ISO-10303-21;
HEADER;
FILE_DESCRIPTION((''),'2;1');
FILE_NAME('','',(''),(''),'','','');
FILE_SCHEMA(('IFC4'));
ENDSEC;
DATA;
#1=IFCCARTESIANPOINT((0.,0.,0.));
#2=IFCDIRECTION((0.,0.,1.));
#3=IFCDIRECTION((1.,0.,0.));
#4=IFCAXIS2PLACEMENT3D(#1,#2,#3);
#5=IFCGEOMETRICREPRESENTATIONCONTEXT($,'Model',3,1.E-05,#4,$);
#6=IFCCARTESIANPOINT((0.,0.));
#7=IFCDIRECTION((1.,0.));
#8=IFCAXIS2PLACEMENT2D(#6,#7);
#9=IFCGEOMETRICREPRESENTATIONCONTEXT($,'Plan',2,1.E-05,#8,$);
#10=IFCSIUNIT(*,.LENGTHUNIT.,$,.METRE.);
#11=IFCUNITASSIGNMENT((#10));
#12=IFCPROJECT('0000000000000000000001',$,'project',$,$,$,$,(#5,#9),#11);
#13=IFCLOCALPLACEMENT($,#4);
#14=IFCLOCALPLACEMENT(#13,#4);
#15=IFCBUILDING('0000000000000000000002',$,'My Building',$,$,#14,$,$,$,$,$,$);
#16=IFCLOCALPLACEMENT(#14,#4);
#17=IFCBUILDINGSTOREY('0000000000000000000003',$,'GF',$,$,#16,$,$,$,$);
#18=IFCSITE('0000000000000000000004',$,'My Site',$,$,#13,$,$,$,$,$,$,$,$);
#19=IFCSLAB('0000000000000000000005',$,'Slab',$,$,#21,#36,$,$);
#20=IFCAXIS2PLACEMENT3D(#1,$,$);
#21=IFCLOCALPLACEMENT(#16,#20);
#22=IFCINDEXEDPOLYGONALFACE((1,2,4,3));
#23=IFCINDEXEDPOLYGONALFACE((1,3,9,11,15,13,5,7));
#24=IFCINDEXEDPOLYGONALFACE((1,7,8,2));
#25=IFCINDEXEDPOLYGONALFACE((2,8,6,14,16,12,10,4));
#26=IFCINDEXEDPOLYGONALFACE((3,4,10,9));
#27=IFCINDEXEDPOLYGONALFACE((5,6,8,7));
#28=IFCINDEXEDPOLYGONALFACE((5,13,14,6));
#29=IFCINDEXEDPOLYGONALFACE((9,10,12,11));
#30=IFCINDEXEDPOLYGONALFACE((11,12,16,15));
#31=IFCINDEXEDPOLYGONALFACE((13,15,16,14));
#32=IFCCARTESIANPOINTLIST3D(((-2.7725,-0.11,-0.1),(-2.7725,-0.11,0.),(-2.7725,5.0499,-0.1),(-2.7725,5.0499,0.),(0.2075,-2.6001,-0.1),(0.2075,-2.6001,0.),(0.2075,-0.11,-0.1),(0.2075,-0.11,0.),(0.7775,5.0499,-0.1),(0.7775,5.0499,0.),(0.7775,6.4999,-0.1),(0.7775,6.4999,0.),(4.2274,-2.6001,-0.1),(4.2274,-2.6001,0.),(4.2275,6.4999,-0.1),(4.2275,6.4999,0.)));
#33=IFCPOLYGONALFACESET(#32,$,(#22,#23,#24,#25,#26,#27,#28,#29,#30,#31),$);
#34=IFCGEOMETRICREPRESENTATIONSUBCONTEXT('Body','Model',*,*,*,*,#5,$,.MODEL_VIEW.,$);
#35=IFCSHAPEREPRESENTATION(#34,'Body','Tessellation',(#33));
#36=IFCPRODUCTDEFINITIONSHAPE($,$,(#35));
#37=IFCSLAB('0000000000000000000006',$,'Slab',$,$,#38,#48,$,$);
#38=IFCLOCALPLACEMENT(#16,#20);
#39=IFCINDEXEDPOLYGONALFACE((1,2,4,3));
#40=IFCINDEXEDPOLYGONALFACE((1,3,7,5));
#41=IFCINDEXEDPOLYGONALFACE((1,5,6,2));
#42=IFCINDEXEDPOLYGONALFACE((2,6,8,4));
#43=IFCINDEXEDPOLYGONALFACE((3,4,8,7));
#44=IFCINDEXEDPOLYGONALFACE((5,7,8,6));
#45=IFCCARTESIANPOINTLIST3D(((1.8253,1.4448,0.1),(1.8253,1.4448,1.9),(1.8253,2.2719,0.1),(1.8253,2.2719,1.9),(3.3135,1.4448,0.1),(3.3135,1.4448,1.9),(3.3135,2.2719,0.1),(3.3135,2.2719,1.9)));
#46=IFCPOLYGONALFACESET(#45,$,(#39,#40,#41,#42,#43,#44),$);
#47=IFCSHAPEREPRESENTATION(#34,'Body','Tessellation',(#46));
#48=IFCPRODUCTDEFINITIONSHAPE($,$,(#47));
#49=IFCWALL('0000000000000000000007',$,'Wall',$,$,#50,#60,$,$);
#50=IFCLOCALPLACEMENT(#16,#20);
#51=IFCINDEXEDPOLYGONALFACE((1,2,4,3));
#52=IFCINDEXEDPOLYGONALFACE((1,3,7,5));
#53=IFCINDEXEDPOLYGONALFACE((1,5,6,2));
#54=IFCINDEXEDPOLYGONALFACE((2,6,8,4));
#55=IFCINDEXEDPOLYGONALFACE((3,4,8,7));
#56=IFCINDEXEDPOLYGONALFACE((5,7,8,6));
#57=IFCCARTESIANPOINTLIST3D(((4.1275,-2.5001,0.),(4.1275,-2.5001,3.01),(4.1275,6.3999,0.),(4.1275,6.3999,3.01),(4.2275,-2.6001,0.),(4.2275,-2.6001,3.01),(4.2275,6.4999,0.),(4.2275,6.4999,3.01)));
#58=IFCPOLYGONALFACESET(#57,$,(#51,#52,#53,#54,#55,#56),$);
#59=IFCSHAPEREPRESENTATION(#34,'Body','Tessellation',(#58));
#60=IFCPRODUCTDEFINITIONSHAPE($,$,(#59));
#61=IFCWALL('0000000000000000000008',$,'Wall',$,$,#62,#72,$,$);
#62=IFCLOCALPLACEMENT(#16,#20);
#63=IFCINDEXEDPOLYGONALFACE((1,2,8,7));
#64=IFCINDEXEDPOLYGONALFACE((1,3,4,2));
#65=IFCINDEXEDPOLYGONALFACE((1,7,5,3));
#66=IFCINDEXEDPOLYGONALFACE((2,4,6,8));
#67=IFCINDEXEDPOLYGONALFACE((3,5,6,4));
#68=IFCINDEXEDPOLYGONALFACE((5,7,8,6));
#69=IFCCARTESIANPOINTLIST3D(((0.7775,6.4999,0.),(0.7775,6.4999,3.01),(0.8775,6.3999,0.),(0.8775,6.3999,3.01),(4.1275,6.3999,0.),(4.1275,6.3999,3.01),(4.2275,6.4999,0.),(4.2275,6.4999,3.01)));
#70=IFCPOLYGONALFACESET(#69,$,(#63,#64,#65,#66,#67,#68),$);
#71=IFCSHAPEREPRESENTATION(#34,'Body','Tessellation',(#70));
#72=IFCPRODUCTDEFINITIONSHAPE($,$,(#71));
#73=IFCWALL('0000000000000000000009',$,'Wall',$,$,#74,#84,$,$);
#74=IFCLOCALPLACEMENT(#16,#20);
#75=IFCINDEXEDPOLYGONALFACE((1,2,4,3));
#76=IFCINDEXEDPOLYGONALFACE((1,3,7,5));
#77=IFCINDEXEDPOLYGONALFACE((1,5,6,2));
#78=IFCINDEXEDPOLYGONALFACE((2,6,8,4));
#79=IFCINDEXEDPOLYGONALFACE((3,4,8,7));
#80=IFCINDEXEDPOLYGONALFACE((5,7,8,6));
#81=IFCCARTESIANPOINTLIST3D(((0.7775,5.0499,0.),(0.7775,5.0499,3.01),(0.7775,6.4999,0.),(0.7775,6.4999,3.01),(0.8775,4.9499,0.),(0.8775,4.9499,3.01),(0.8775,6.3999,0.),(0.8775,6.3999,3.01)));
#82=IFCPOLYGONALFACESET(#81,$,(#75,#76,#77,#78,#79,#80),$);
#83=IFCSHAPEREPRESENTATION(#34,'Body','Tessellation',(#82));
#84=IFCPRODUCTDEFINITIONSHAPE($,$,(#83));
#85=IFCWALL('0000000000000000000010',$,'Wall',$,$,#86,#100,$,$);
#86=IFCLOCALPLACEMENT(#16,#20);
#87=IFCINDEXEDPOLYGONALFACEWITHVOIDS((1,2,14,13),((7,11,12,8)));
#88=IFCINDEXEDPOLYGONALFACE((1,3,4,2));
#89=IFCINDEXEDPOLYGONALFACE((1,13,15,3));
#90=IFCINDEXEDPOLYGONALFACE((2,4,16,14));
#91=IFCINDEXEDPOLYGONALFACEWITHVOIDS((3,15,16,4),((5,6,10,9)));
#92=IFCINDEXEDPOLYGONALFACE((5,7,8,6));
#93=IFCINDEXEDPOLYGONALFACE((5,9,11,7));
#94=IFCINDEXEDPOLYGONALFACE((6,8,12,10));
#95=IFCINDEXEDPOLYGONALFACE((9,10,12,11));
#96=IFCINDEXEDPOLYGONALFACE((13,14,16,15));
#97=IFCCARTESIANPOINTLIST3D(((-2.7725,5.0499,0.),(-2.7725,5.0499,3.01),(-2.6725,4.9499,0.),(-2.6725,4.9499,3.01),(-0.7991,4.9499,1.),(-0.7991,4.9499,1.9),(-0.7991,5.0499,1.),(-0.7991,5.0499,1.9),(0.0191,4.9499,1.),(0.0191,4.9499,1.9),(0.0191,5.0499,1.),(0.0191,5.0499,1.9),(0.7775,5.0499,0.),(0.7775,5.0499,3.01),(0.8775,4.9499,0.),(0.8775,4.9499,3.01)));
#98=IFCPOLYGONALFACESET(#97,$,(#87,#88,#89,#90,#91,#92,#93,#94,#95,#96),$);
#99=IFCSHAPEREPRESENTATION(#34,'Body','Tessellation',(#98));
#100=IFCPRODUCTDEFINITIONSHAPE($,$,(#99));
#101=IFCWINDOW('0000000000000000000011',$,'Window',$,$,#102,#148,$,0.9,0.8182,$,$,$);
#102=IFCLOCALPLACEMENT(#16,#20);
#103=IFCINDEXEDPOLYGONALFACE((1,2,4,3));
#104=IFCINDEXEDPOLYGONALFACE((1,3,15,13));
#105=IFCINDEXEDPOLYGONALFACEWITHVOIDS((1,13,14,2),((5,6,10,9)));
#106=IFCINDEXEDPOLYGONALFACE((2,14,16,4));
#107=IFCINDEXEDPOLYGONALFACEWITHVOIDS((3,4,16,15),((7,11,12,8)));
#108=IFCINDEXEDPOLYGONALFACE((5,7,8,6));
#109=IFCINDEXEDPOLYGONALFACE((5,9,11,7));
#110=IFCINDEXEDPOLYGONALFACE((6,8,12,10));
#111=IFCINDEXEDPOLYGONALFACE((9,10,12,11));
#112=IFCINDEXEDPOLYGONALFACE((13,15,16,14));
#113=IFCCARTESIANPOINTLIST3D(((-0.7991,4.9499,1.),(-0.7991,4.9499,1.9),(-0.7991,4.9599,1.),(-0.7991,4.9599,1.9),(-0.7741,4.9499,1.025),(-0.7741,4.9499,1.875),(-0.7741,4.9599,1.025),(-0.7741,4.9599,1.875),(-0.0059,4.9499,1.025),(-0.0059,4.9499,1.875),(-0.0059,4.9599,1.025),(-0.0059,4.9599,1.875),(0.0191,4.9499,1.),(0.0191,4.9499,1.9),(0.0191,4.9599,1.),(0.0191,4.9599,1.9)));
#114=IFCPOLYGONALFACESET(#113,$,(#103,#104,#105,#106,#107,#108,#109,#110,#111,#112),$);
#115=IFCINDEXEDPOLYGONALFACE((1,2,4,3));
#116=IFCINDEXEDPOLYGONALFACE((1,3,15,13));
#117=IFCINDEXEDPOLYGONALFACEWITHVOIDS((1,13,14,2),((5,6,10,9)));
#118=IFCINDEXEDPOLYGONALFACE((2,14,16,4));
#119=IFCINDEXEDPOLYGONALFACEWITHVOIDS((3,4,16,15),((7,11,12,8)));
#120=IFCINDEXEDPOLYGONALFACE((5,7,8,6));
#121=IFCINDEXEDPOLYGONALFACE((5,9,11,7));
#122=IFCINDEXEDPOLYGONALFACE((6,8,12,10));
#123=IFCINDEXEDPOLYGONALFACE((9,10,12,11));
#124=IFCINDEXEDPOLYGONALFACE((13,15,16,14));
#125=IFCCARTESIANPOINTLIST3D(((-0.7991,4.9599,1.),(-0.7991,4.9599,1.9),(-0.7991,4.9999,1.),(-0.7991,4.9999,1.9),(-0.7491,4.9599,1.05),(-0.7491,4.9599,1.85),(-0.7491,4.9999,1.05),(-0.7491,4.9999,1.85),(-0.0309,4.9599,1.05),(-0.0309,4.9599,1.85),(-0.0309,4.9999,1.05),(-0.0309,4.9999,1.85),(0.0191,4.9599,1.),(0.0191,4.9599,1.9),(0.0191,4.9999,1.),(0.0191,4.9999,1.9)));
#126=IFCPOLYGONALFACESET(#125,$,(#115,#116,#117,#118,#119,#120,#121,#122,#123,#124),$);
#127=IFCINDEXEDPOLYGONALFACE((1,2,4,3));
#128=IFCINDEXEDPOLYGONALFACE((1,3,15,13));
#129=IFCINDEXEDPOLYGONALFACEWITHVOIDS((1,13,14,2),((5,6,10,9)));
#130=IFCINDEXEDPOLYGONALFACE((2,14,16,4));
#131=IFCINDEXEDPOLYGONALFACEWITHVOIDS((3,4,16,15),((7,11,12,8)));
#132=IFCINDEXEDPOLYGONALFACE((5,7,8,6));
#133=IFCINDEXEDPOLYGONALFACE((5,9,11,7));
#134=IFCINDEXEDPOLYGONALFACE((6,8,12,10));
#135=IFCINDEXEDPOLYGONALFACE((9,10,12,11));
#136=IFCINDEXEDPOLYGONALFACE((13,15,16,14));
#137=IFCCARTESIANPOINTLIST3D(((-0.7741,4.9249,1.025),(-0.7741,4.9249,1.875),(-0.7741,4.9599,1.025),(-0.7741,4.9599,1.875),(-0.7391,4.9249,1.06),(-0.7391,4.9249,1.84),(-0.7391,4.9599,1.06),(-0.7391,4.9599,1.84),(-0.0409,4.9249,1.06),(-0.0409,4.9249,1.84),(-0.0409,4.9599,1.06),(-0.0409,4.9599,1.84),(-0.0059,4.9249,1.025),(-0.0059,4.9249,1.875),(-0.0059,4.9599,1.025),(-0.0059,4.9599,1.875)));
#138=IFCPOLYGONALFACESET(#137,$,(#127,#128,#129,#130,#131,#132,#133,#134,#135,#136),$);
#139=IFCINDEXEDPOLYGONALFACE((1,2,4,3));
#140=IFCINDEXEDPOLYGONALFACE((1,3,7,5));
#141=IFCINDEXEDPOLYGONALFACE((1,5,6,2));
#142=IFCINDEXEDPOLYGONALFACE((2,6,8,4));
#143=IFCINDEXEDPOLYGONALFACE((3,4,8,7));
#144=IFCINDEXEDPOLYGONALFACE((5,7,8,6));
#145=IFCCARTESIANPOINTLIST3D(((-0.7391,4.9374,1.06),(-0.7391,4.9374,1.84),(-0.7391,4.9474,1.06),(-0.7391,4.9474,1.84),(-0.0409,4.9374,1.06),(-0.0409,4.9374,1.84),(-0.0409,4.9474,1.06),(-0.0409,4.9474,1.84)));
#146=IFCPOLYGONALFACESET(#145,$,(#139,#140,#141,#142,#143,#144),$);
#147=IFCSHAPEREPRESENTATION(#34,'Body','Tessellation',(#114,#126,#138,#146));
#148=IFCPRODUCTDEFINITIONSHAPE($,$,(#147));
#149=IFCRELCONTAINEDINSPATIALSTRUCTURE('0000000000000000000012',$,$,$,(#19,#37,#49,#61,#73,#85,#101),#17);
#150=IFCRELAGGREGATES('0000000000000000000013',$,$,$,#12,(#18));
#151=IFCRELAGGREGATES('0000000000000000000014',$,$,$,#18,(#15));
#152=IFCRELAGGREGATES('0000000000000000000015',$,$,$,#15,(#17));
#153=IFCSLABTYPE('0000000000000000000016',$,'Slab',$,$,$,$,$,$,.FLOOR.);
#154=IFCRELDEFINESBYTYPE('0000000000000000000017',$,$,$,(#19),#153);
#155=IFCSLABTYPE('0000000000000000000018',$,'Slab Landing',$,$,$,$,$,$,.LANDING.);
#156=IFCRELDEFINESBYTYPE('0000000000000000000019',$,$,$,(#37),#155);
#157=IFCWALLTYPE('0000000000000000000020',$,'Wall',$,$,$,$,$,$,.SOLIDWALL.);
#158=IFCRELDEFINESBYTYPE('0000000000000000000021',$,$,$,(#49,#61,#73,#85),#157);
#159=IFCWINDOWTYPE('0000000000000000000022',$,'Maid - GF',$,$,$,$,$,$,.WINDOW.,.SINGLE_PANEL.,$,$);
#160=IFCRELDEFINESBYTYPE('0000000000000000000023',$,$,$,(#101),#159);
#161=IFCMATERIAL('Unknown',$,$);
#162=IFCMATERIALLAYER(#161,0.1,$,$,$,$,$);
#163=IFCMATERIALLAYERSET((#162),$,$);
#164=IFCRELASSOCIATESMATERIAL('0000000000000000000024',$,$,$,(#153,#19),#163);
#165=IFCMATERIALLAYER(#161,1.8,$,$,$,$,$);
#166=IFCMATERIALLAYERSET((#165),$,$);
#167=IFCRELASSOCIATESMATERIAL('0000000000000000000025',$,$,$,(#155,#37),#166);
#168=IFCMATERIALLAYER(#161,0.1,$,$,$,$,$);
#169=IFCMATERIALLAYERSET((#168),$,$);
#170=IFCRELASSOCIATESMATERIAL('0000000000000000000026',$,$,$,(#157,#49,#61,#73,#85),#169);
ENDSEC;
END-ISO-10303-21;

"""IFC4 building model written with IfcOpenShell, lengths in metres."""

from ifc_helpers import new_model, entity, si_unit, frame, origin_with_axes, origin_2d_with_axis, place, context, subcontext, project, spatial, line, indexed_curve, outline, extrude, shape, source, transform, mapped, material, layer, layer_set, layer_usage, type_object, type_shapes, element, fill, save


model = new_model("IFC4")

# Units and contexts
model_context = context("Model", 3, precision=1e-05, world=origin_with_axes())
plan_context = context("Plan", 2, precision=1e-05, world=origin_2d_with_axis())
body_context_1 = subcontext(model_context, "Body", "Model", "MODEL_VIEW")
body_context_2 = subcontext(plan_context, "Body", "Plan", "PLAN_VIEW")
ifc_project = project(units=[si_unit("LENGTHUNIT", "METRE")], contexts=[model_context, plan_context])

# Site, building, storey
site_placement = place(None, origin_with_axes())
site = spatial("IfcSite", under=ifc_project, at=site_placement, Name="My Site")
building_placement = place(site_placement, origin_with_axes())
building = spatial("IfcBuilding", under=site, at=building_placement, Name="My Building")
storey_placement = place(building_placement, origin_with_axes())
storey = spatial("IfcBuildingStorey", under=building, at=storey_placement, Name="GF")

# Slabs
ifc_material_1 = material(Name="Unknown")
ifc_layer_1 = layer(ifc_material_1, 0.1)
ifc_layer_set_1 = layer_set([ifc_layer_1])
ifc_layer_usage_1 = layer_usage(ifc_layer_set_1, "AXIS3", "POSITIVE", -0.1)
slab_type_1 = type_object("IfcSlabType", Name="Slab", PredefinedType="FLOOR", material=ifc_layer_set_1)
slab_1_placement = place(storey_placement, frame((4.2275, 6.4999, 0.0), z_axis=(0.0, 0.0, 1.0), x_axis=(1.0, 0.0, 0.0)))
element("IfcSlab", 1, at=slab_1_placement, inside=storey, type_object=slab_type_1, material=ifc_layer_usage_1, Name="Slab", context=body_context_1, shape_type="SweptSolid", body=[
    extrude(outline(indexed_curve([(0.0, 0.0), (-3.45, 0.0), (-3.45, -1.45), (-7.0, -1.45), (-7.0, -6.61), (-4.02, -6.61), (-4.02, -9.1), (-0.0001, -9.1), (0.0, 0.0)])), frame((0.0, 0.0, -0.1), z_axis=(0.0, 0.0, 1.0), x_axis=(1.0, 0.0, 0.0)), (0.0, 0.0, 1.0), 0.1),
])
ifc_layer_2 = layer(ifc_material_1, 1.8)
ifc_layer_set_2 = layer_set([ifc_layer_2])
slab_type_2 = type_object("IfcSlabType", Name="Slab Landing", PredefinedType="LANDING", material=ifc_layer_set_2)
ifc_layer_usage_2 = layer_usage(ifc_layer_set_2, "AXIS3", "POSITIVE", -1.8)
slab_2_placement = place(storey_placement, frame((3.3135, 2.2719, 1.9), z_axis=(0.0, 0.0, 1.0), x_axis=(1.0, 0.0, 0.0)))
element("IfcSlab", 2, at=slab_2_placement, inside=storey, type_object=slab_type_2, material=ifc_layer_usage_2, Name="Slab", context=body_context_1, shape_type="SweptSolid", body=[
    extrude(outline(indexed_curve([(0.0, 0.0), (0.0, -0.827), (-1.4882, -0.827), (-1.4882, 0.0), (0.0, 0.0)])), frame((0.0, 0.0, -1.8), z_axis=(0.0, 0.0, 1.0), x_axis=(1.0, 0.0, 0.0)), (0.0, 0.0, 1.0), 1.8),
])

# Shared definitions
ifc_layer_3 = layer(ifc_material_1, 0.1)
ifc_layer_set_3 = layer_set([ifc_layer_3])
wall_type = type_object("IfcWallType", Name="Wall", PredefinedType="SOLIDWALL", material=ifc_layer_set_3)

# Walls
ifc_layer_usage_3 = layer_usage(ifc_layer_set_3, "AXIS2", "POSITIVE", 0.0)
wall_1_placement = place(storey_placement, frame((4.2275, -2.6001, 0.0), z_axis=(0.0, 0.0, 1.0), x_axis=(0.0, 1.0, 0.0)))
element("IfcWall", 3, at=wall_1_placement, inside=storey, type_object=wall_type, material=ifc_layer_usage_3, Name="Wall", context=body_context_1, shape_type="SweptSolid", body=[
    extrude(outline(indexed_curve([(0.0, 0.0), (0.1, 0.1), (9.0, 0.1), (9.1, 0.0)], segments=[line(1, 2, 3, 4, 1)])), origin_with_axes(), (0.0, 0.0, 1.0), 3.01),
])
ifc_layer_usage_4 = layer_usage(ifc_layer_set_3, "AXIS2", "POSITIVE", 0.0)
wall_2_placement = place(storey_placement, frame((4.2275, 6.4999, 0.0), z_axis=(0.0, 0.0, 1.0), x_axis=(-1.0, 0.0, 0.0)))
element("IfcWall", 4, at=wall_2_placement, inside=storey, type_object=wall_type, material=ifc_layer_usage_4, Name="Wall", context=body_context_1, shape_type="SweptSolid", body=[
    extrude(outline(indexed_curve([(0.0, 0.0), (0.1, 0.1), (3.35, 0.1), (3.45, 0.0)], segments=[line(1, 2, 3, 4, 1)])), origin_with_axes(), (0.0, 0.0, 1.0), 3.01),
])
ifc_layer_usage_5 = layer_usage(ifc_layer_set_3, "AXIS2", "POSITIVE", 0.0)
wall_3_placement = place(storey_placement, frame((0.7775, 6.4999, 0.0), z_axis=(0.0, 0.0, 1.0), x_axis=(0.0, -1.0, 0.0)))
element("IfcWall", 5, at=wall_3_placement, inside=storey, type_object=wall_type, material=ifc_layer_usage_5, Name="Wall", context=body_context_1, shape_type="SweptSolid", body=[
    extrude(outline(indexed_curve([(0.0, 0.0), (0.1, 0.1), (1.55, 0.1), (1.45, 0.0)], segments=[line(1, 2, 3, 4, 1)])), origin_with_axes(), (0.0, 0.0, 1.0), 3.01),
])

# Wall, opening, window
ifc_layer_usage_6 = layer_usage(ifc_layer_set_3, "AXIS2", "POSITIVE", 0.0)
wall_4_placement = place(storey_placement, frame((0.7775, 5.0499, 0.0), z_axis=(0.0, 0.0, 1.0), x_axis=(-1.0, 0.0, 0.0)))
wall_4 = element("IfcWall", 6, at=wall_4_placement, inside=storey, type_object=wall_type, material=ifc_layer_usage_6, Name="Wall", context=body_context_1, shape_type="SweptSolid", body=[
    extrude(outline(indexed_curve([(0.0, 0.0), (-0.1, 0.1), (3.45, 0.1), (3.55, 0.0)], segments=[line(1, 2, 3, 4, 1)])), origin_with_axes(), (0.0, 0.0, 1.0), 3.01),
])
shared_shape_1 = source(origin_with_axes(), body_context_1, "Body", "SweptSolid", [
    extrude(outline(indexed_curve([(0.0, 0.0), (0.8182, 0.0), (0.8182, 0.9), (0.0, 0.9)], segments=[line(1, 2, 3, 4, 1)])), frame((0.0, -0.6, 0.0), z_axis=(0.0, -1.0, 0.0), x_axis=(1.0, 0.0, 0.0)), (0.0, 0.0, -1.0), 1.2),
])
opening_1_placement = place(wall_4_placement, frame((0.7584, 0.0, 1.0), z_axis=(0.0, 0.0, 1.0), x_axis=(1.0, 0.0, 0.0)))
opening_1 = element("IfcOpeningElement", 7, at=opening_1_placement, cuts=wall_4, PredefinedType="OPENING", context=body_context_1, shape_type="MappedRepresentation", body=[
    mapped(shared_shape_1, transform((0.0, 0.0, 0.0), x_axis=(1.0, 0.0, 0.0), y_axis=(0.0, 1.0, 0.0), z_axis=(0.0, 0.0, 1.0), scale=1.0)),
])
window_type_1 = type_object("IfcWindowType", Name="Maid - GF", PartitioningType="SINGLE_PANEL", PredefinedType="WINDOW")
shared_shape_2 = source(origin_with_axes(), body_context_1, "Body", "SweptSolid", [
    extrude(outline(indexed_curve([(0.0, 0.0), (0.8182, 0.0), (0.8182, 0.9), (0.0, 0.9)], segments=[line(1, 2, 3, 4, 1)]), holes=[indexed_curve([(0.025, 0.025), (0.7932, 0.025), (0.7932, 0.875), (0.025, 0.875)], segments=[line(1, 2, 3, 4, 1)])]), frame((0.0, 0.09, 0.0), z_axis=(0.0, -1.0, 0.0), x_axis=(1.0, 0.0, 0.0)), (0.0, 0.0, -1.0), 0.01),
    extrude(outline(indexed_curve([(0.0, 0.0), (0.8182, 0.0), (0.8182, 0.9), (0.0, 0.9)], segments=[line(1, 2, 3, 4, 1)]), holes=[indexed_curve([(0.05, 0.05), (0.7682, 0.05), (0.7682, 0.85), (0.05, 0.85)], segments=[line(1, 2, 3, 4, 1)])]), frame((0.0, 0.05, 0.0), z_axis=(0.0, -1.0, 0.0), x_axis=(1.0, 0.0, 0.0)), (0.0, 0.0, -1.0), 0.04),
    extrude(outline(indexed_curve([(0.0, 0.0), (0.7682, 0.0), (0.7682, 0.85), (0.0, 0.85)], segments=[line(1, 2, 3, 4, 1)]), holes=[indexed_curve([(0.035, 0.035), (0.7332, 0.035), (0.7332, 0.815), (0.035, 0.815)], segments=[line(1, 2, 3, 4, 1)])]), frame((0.025, 0.09, 0.025), z_axis=(0.0, -1.0, 0.0), x_axis=(1.0, 0.0, 0.0)), (0.0, 0.0, -1.0), 0.035),
    extrude(outline(indexed_curve([(0.035, 0.035), (0.7332, 0.035), (0.7332, 0.815), (0.035, 0.815)], segments=[line(1, 2, 3, 4, 1)])), frame((0.025, 0.1025, 0.025), z_axis=(0.0, -1.0, 0.0), x_axis=(1.0, 0.0, 0.0)), (0.0, 0.0, -1.0), 0.01),
])
shared_shape_3 = source(origin_with_axes(), body_context_2, "Body", "Curve2D", [
    entity("IfcIndexedPolyCurve", entity("IfcCartesianPointList2D", [[0.05, 0.05], [0.7682, 0.05]])),
    entity("IfcIndexedPolyCurve", entity("IfcCartesianPointList2D", [[0.0, 0.1], [0.025, 0.1], [0.025, 0.09], [0.05, 0.09], [0.05, 0.05], [0.0, 0.05]]), [entity("IfcLineIndex", [1, 2, 3, 4, 5, 6, 1])]),
    entity("IfcIndexedPolyCurve", entity("IfcCartesianPointList2D", [[0.8182, 0.1], [0.7932, 0.1], [0.7932, 0.09], [0.7682, 0.09], [0.7682, 0.05], [0.8182, 0.05]]), [entity("IfcLineIndex", [1, 2, 3, 4, 5, 6, 1])]),
    entity("IfcIndexedPolyCurve", entity("IfcCartesianPointList2D", [[0.025, 0.09], [0.06, 0.09], [0.06, 0.125], [0.025, 0.125]]), [entity("IfcLineIndex", [1, 2, 3, 4, 1])]),
    entity("IfcIndexedPolyCurve", entity("IfcCartesianPointList2D", [[0.7932, 0.09], [0.7582, 0.09], [0.7582, 0.125], [0.7932, 0.125]]), [entity("IfcLineIndex", [1, 2, 3, 4, 1])]),
    entity("IfcIndexedPolyCurve", entity("IfcCartesianPointList2D", [[0.06, 0.09], [0.7582, 0.09]])),
    entity("IfcIndexedPolyCurve", entity("IfcCartesianPointList2D", [[0.06, 0.125], [0.7582, 0.125]])),
    entity("IfcIndexedPolyCurve", entity("IfcCartesianPointList2D", [[0.06, 0.1075], [0.7582, 0.1075]])),
])
type_shapes(window_type_1, [shared_shape_2, shared_shape_3])
window_1_placement = place(opening_1_placement, frame((0.0, 0.0, 0.0), z_axis=(0.0, 0.0, 1.0), x_axis=(1.0, 0.0, 0.0)))
window_1 = element("IfcWindow", 8, at=window_1_placement, inside=storey, type_object=window_type_1, Name="Window", OverallHeight=0.9, OverallWidth=0.8182, shapes=[
    shape(body_context_1, "Body", "MappedRepresentation", [mapped(shared_shape_2, transform((0.0, 0.0, 0.0), x_axis=(1.0, 0.0, 0.0), y_axis=(0.0, 1.0, 0.0), z_axis=(0.0, 0.0, 1.0), scale=1.0))]),
    shape(body_context_2, "Body", "MappedRepresentation", [mapped(shared_shape_3, transform((0.0, 0.0, 0.0), x_axis=(1.0, 0.0, 0.0), y_axis=(0.0, 1.0, 0.0), z_axis=(0.0, 0.0, 1.0), scale=1.0))]),
])
fill(opening_1, window_1)

save(model, "model.ifc")
